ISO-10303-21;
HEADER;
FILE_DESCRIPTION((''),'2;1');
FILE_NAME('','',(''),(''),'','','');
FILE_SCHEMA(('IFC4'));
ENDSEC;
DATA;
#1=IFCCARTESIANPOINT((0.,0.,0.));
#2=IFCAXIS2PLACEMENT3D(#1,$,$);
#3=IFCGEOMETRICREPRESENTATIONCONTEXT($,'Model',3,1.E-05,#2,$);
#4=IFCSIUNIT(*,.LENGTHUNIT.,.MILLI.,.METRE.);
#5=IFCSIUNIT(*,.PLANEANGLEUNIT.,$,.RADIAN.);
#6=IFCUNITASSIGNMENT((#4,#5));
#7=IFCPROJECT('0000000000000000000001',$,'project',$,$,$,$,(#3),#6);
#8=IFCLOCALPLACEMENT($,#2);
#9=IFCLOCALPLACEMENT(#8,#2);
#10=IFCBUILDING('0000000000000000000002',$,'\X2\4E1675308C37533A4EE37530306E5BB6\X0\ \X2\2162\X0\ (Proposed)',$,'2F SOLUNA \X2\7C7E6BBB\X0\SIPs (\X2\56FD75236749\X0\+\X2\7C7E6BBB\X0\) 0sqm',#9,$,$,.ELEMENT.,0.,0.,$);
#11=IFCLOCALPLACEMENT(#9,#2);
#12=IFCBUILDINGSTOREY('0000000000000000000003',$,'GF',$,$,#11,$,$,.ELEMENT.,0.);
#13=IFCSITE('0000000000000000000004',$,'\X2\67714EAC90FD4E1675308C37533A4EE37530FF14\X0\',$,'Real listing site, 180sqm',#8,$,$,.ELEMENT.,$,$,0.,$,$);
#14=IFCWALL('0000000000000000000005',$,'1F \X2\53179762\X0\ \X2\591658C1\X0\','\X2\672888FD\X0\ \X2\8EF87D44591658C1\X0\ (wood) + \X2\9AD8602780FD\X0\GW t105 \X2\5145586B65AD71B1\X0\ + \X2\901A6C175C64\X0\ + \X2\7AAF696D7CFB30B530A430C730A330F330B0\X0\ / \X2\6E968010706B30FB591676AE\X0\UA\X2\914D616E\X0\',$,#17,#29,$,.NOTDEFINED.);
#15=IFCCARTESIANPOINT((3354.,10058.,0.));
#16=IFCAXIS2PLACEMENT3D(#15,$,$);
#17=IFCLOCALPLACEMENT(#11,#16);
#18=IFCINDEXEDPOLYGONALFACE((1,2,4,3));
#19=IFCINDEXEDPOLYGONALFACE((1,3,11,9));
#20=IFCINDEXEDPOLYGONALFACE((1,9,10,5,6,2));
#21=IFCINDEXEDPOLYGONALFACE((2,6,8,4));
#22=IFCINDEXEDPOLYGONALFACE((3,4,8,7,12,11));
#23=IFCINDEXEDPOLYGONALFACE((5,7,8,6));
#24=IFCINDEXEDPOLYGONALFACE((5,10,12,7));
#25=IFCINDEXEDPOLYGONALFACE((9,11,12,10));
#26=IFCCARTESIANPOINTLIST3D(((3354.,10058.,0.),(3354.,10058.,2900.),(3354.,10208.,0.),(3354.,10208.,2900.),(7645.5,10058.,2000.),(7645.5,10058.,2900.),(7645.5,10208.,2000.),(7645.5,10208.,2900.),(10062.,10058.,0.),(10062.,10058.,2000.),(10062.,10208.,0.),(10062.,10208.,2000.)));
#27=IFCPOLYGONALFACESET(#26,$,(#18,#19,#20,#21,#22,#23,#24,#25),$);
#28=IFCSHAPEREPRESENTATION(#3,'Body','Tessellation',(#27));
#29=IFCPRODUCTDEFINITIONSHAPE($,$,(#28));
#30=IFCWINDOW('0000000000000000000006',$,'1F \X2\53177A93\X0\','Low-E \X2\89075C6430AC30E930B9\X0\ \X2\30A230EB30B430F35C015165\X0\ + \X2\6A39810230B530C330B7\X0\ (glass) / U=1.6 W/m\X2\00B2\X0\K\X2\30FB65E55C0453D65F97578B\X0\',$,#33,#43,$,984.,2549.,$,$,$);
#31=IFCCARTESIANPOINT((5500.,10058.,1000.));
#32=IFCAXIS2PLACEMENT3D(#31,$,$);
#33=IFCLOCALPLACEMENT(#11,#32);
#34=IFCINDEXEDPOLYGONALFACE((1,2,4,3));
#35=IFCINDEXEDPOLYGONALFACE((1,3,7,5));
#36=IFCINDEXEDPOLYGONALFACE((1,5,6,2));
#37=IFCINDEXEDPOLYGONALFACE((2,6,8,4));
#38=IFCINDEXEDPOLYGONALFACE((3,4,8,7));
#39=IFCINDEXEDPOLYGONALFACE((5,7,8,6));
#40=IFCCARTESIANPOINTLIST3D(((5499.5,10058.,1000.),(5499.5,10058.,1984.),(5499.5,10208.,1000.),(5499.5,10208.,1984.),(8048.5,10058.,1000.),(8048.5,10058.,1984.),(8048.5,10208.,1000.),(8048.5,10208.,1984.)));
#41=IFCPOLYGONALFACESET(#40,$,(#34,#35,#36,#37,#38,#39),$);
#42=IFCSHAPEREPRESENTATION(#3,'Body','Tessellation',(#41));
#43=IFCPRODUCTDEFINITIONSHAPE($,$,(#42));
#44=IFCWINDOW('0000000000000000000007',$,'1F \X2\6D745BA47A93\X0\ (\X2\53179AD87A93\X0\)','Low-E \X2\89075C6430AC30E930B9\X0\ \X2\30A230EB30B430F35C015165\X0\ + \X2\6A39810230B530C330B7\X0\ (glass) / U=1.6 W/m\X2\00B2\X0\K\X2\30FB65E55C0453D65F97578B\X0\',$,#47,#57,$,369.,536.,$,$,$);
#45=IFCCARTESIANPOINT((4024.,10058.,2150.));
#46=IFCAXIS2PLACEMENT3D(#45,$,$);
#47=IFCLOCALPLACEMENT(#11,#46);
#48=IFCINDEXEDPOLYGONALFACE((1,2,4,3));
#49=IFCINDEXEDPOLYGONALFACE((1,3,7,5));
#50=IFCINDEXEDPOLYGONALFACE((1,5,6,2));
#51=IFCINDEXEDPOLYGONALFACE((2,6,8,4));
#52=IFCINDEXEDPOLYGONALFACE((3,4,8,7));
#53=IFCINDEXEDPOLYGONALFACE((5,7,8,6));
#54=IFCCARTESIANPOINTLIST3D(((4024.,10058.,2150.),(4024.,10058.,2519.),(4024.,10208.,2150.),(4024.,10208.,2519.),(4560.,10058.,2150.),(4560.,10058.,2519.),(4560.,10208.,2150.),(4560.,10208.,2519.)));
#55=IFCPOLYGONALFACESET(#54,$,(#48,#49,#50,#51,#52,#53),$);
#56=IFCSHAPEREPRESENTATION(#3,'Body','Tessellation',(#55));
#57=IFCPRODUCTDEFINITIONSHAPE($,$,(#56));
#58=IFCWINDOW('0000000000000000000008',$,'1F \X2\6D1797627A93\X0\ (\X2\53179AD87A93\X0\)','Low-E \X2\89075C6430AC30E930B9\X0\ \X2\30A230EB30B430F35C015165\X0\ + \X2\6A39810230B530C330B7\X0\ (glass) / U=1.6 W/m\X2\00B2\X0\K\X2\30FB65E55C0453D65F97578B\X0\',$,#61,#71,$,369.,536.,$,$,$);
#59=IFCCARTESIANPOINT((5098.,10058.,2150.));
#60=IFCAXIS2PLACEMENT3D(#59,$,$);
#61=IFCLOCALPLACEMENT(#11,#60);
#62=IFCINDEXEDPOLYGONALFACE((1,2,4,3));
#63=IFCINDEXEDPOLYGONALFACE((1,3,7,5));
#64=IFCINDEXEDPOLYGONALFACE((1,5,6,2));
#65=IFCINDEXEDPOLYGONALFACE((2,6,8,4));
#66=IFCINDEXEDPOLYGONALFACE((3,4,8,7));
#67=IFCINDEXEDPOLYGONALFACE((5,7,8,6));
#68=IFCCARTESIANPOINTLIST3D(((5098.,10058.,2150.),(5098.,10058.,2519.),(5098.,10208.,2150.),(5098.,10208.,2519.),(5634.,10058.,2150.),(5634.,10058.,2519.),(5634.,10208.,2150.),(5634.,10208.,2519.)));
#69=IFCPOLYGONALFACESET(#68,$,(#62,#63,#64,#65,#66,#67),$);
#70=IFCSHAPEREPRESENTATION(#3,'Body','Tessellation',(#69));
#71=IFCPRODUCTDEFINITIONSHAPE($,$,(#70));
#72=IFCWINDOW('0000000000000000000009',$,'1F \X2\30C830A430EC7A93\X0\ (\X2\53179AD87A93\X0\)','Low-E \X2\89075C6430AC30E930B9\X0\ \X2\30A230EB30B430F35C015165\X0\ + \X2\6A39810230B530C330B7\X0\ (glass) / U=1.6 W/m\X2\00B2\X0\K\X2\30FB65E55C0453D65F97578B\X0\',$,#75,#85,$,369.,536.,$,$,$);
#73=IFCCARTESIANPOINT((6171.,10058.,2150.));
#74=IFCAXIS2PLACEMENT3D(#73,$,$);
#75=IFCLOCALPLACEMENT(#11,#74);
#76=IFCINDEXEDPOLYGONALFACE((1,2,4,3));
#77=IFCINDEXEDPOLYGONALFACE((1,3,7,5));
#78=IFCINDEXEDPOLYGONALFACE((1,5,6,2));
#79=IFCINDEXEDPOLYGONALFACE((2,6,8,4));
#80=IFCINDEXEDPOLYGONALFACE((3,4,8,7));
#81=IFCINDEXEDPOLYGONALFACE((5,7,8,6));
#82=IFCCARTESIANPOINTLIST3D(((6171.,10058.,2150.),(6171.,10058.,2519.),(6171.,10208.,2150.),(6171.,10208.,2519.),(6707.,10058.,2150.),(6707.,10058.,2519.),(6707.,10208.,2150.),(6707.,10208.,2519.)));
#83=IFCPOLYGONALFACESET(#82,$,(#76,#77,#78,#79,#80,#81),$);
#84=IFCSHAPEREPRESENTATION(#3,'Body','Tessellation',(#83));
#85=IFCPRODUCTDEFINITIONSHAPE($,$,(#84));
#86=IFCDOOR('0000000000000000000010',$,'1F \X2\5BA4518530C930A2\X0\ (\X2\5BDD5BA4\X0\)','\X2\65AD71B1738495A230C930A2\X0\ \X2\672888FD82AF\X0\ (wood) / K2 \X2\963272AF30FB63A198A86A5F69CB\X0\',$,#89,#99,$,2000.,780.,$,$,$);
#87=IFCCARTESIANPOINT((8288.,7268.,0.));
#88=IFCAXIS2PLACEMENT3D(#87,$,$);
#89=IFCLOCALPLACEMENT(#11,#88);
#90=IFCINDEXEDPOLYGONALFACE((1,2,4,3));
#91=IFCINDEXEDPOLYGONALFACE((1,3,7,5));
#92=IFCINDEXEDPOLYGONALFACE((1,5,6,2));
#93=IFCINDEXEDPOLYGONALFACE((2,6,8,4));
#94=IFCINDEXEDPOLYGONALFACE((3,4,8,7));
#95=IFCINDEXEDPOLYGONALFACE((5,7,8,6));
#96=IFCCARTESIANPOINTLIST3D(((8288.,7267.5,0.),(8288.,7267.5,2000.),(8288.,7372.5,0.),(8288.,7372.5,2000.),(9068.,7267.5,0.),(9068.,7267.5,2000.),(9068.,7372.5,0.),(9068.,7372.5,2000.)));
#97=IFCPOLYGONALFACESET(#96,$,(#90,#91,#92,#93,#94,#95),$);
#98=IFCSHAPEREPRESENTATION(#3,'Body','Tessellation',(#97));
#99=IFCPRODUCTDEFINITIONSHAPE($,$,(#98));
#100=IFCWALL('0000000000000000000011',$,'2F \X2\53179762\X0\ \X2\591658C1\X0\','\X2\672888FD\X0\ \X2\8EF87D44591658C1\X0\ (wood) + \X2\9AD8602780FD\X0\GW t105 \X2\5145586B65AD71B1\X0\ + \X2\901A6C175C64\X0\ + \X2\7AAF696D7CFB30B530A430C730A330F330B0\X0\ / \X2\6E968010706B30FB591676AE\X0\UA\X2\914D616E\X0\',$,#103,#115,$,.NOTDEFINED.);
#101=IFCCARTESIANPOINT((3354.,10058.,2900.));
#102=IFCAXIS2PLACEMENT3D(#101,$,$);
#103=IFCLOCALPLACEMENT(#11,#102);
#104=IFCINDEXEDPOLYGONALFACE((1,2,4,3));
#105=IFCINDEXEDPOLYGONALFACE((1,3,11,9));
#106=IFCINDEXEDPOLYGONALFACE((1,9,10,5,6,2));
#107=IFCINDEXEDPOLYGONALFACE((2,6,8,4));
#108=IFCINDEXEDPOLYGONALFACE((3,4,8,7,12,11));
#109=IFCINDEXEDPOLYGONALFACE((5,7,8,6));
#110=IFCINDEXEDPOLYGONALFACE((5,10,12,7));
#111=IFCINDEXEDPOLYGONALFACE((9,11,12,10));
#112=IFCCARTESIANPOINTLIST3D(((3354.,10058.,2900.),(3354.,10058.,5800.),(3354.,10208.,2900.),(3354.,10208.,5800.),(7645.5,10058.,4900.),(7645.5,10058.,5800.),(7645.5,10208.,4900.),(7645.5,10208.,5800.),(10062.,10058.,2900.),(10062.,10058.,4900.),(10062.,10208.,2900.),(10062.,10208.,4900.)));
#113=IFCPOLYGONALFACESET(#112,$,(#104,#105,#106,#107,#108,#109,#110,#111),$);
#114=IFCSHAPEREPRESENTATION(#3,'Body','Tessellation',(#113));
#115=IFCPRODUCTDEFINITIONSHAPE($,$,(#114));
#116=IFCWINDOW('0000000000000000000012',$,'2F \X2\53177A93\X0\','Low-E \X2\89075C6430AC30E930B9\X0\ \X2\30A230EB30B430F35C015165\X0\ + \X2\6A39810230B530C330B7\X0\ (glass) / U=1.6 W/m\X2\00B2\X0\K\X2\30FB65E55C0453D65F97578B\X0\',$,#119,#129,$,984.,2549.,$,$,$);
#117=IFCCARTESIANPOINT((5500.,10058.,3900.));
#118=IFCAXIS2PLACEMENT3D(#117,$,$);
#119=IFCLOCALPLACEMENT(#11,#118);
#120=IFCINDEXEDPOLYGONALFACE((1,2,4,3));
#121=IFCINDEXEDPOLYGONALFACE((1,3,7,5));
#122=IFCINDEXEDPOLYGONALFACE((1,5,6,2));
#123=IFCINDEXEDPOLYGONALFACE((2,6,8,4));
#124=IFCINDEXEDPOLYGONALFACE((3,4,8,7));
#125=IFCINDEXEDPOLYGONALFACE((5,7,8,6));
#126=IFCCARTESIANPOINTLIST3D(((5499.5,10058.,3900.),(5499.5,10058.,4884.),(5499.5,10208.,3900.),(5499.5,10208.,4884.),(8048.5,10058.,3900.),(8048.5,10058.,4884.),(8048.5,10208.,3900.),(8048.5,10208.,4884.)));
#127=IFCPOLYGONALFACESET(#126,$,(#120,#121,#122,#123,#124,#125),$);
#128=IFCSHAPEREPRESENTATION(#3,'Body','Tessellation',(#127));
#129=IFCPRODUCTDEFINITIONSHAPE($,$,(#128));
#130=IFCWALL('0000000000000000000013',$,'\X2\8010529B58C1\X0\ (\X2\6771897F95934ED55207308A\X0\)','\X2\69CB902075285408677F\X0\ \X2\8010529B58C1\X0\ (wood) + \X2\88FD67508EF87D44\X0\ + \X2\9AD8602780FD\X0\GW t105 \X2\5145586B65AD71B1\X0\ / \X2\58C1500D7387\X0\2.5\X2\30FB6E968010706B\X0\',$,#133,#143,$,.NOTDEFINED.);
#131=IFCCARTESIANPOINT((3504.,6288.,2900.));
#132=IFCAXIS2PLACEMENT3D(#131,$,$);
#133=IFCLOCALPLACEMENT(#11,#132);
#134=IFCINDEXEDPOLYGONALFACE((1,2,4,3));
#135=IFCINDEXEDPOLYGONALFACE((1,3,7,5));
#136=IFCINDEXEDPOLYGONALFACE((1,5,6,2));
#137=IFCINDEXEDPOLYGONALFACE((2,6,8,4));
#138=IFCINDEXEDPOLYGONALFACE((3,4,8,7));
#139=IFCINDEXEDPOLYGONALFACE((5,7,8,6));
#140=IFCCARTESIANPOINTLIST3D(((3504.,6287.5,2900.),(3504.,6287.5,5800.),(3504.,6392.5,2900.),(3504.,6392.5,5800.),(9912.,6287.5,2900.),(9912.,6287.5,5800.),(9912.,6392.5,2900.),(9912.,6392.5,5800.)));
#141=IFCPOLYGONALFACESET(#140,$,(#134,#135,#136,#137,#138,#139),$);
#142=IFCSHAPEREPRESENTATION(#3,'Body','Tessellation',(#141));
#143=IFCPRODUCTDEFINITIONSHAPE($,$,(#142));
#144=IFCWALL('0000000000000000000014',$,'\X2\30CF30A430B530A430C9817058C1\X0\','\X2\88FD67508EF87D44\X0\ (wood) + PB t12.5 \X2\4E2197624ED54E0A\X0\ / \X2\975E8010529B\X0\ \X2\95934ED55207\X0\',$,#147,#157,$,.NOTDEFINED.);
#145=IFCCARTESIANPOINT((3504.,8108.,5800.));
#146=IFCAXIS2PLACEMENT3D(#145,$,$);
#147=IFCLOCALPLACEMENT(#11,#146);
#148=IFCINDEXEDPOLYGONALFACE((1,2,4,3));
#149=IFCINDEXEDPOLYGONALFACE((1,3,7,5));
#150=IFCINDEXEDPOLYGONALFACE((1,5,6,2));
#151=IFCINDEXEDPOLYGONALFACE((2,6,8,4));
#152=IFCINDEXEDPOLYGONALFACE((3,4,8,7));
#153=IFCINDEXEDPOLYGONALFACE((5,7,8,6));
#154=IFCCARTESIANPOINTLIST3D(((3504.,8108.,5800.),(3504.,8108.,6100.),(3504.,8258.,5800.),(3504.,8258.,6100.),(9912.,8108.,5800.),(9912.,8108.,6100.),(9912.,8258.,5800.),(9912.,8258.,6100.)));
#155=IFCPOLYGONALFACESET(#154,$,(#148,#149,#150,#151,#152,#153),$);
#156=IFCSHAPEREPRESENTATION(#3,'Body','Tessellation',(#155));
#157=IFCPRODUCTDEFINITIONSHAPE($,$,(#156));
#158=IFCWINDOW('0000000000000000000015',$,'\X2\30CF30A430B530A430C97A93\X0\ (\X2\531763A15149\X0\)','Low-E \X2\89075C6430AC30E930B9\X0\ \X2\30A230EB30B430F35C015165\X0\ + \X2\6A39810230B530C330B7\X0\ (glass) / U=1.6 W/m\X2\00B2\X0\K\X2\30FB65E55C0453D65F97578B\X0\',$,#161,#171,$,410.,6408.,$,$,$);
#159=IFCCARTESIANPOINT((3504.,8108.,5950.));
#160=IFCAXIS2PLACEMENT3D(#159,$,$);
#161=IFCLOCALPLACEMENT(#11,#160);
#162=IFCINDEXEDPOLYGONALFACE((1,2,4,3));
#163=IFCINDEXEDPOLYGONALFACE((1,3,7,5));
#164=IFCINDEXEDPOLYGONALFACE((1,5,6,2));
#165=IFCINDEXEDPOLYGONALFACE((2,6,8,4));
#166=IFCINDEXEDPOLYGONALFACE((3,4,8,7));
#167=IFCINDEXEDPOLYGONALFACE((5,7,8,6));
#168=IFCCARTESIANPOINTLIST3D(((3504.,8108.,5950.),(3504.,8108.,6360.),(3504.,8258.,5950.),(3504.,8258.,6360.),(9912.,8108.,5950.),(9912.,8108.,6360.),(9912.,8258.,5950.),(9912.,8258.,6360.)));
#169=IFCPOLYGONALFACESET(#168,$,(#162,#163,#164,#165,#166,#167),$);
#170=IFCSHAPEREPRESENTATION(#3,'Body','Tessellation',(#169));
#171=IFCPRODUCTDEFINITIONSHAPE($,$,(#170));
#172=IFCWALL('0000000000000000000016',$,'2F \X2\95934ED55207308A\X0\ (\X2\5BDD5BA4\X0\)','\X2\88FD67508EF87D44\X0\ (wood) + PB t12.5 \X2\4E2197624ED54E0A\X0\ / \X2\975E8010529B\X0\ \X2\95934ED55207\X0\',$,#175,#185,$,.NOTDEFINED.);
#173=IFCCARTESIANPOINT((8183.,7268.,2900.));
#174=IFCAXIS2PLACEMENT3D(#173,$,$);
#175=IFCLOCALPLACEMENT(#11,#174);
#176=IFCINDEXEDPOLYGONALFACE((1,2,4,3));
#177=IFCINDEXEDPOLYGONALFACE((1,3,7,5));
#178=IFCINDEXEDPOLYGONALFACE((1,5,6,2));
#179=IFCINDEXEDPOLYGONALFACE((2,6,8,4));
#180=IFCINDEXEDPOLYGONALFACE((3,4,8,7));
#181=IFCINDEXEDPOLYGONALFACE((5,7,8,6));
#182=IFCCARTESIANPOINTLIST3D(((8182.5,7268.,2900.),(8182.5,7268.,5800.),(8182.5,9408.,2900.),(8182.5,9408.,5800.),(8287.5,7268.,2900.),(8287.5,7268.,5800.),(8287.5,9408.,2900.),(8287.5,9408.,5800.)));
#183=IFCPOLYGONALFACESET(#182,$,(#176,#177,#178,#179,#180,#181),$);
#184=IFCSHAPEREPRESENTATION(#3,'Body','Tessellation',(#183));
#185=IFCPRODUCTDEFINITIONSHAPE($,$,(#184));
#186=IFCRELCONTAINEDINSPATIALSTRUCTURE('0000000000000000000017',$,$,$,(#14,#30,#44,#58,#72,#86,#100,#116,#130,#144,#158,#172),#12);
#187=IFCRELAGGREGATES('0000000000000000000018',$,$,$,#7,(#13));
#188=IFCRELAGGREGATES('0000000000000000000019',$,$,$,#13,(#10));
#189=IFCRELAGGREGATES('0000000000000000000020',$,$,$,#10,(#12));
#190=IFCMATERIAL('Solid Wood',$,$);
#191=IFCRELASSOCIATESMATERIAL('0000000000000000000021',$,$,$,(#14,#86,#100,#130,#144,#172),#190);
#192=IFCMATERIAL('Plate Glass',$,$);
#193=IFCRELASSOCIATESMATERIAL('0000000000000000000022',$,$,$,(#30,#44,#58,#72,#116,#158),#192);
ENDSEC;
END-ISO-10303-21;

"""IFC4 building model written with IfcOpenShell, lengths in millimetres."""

from ifc_helpers import new_model, si_unit, frame, frame_2d, origin, place, context, project, spatial, rectangle, extrude, material, element, fill, save


model = new_model("IFC4")

# Units and contexts
model_context = context("Model", 3, precision=1e-05, world=origin())
ifc_project = project(units=[si_unit("LENGTHUNIT", "METRE", prefix="MILLI"), si_unit("PLANEANGLEUNIT", "RADIAN")], contexts=[model_context])

# Site, building, storey
site_placement = place(None, origin())
site = spatial("IfcSite", under=ifc_project, at=site_placement, Name="東京都世田谷区代田４", ObjectType="Real listing site, 180sqm", CompositionType="ELEMENT", RefElevation=0.0)
building_placement = place(site_placement, origin())
building = spatial("IfcBuilding", under=site, at=building_placement, Name="世田谷区代田の家 Ⅲ (Proposed)", ObjectType="2F SOLUNA 籾殻SIPs (国産杉+籾殻) 0sqm", CompositionType="ELEMENT", ElevationOfRefHeight=0.0, ElevationOfTerrain=0.0)
storey_placement = place(building_placement, origin())
storey = spatial("IfcBuildingStorey", under=building, at=storey_placement, Name="GF", CompositionType="ELEMENT", Elevation=0.0)

# Wall, openings, windows
ifc_material_1 = material(Name="Solid Wood")
wall_1_placement = place(storey_placement, frame((3354.0, 10058.0, 0.0)))
wall_1 = element("IfcWall", 1, at=wall_1_placement, inside=storey, material=ifc_material_1, Name="1F 北面 外壁", Description="木製 軸組外壁 (wood) + 高性能GW t105 充填断熱 + 通気層 + 窯業系サイディング / 準耐火・外皮UA配慮", PredefinedType="NOTDEFINED", context=model_context, shape_type="SweptSolid", body=[
    extrude(rectangle(XDim=6708.0, YDim=150.0, at=frame_2d((3354.0, 75.0))), frame((3354.0, 10058.0, 0.0)), (0.0, 0.0, 1.0), 2900.0),
])
opening_1_placement = place(storey_placement, frame((5500.0, 10058.0, 1000.0)))
opening_1 = element("IfcOpeningElement", 2, at=opening_1_placement, cuts=wall_1, PredefinedType="NOTDEFINED", context=model_context, shape_type="SweptSolid", body=[
    extrude(rectangle(XDim=2549.0, YDim=150.0, at=frame_2d((1274.0, 75.0))), frame((5500.0, 10058.0, 1000.0)), (0.0, 0.0, 1.0), 984.0),
])
opening_2_placement = place(storey_placement, frame((4024.0, 10058.0, 2150.0)))
opening_2 = element("IfcOpeningElement", 3, at=opening_2_placement, cuts=wall_1, PredefinedType="NOTDEFINED", context=model_context, shape_type="SweptSolid", body=[
    extrude(rectangle(XDim=536.0, YDim=150.0, at=frame_2d((268.0, 75.0))), frame((4024.0, 10058.0, 2150.0)), (0.0, 0.0, 1.0), 369.0),
])
opening_3_placement = place(storey_placement, frame((5098.0, 10058.0, 2150.0)))
opening_3 = element("IfcOpeningElement", 4, at=opening_3_placement, cuts=wall_1, PredefinedType="NOTDEFINED", context=model_context, shape_type="SweptSolid", body=[
    extrude(rectangle(XDim=536.0, YDim=150.0, at=frame_2d((268.0, 75.0))), frame((5098.0, 10058.0, 2150.0)), (0.0, 0.0, 1.0), 369.0),
])
opening_4_placement = place(storey_placement, frame((6171.0, 10058.0, 2150.0)))
opening_4 = element("IfcOpeningElement", 5, at=opening_4_placement, cuts=wall_1, PredefinedType="NOTDEFINED", context=model_context, shape_type="SweptSolid", body=[
    extrude(rectangle(XDim=536.0, YDim=150.0, at=frame_2d((268.0, 75.0))), frame((6171.0, 10058.0, 2150.0)), (0.0, 0.0, 1.0), 369.0),
])
ifc_material_2 = material(Name="Plate Glass")
window_1_placement = place(storey_placement, frame((5500.0, 10058.0, 1000.0)))
window_1 = element("IfcWindow", 6, at=window_1_placement, inside=storey, material=ifc_material_2, Name="1F 北窓", Description="Low-E 複層ガラス アルゴン封入 + 樹脂サッシ (glass) / U=1.6 W/m²K・日射取得型", OverallHeight=984.0, OverallWidth=2549.0, context=model_context, shape_type="SweptSolid", body=[
    extrude(rectangle(XDim=2549.0, YDim=150.0, at=frame_2d((1274.0, 75.0))), frame((5500.0, 10058.0, 1000.0)), (0.0, 0.0, 1.0), 984.0),
])
fill(opening_1, window_1)
window_2_placement = place(storey_placement, frame((4024.0, 10058.0, 2150.0)))
window_2 = element("IfcWindow", 7, at=window_2_placement, inside=storey, material=ifc_material_2, Name="1F 浴室窓 (北高窓)", Description="Low-E 複層ガラス アルゴン封入 + 樹脂サッシ (glass) / U=1.6 W/m²K・日射取得型", OverallHeight=369.0, OverallWidth=536.0, context=model_context, shape_type="SweptSolid", body=[
    extrude(rectangle(XDim=536.0, YDim=150.0, at=frame_2d((268.0, 75.0))), frame((4024.0, 10058.0, 2150.0)), (0.0, 0.0, 1.0), 369.0),
])
fill(opening_2, window_2)
window_3_placement = place(storey_placement, frame((5098.0, 10058.0, 2150.0)))
window_3 = element("IfcWindow", 8, at=window_3_placement, inside=storey, material=ifc_material_2, Name="1F 洗面窓 (北高窓)", Description="Low-E 複層ガラス アルゴン封入 + 樹脂サッシ (glass) / U=1.6 W/m²K・日射取得型", OverallHeight=369.0, OverallWidth=536.0, context=model_context, shape_type="SweptSolid", body=[
    extrude(rectangle(XDim=536.0, YDim=150.0, at=frame_2d((268.0, 75.0))), frame((5098.0, 10058.0, 2150.0)), (0.0, 0.0, 1.0), 369.0),
])
fill(opening_3, window_3)
window_4_placement = place(storey_placement, frame((6171.0, 10058.0, 2150.0)))
window_4 = element("IfcWindow", 9, at=window_4_placement, inside=storey, material=ifc_material_2, Name="1F トイレ窓 (北高窓)", Description="Low-E 複層ガラス アルゴン封入 + 樹脂サッシ (glass) / U=1.6 W/m²K・日射取得型", OverallHeight=369.0, OverallWidth=536.0, context=model_context, shape_type="SweptSolid", body=[
    extrude(rectangle(XDim=536.0, YDim=150.0, at=frame_2d((268.0, 75.0))), frame((6171.0, 10058.0, 2150.0)), (0.0, 0.0, 1.0), 369.0),
])
fill(opening_4, window_4)

# Door
door_1_placement = place(storey_placement, frame((8288.0, 7268.0, 0.0)))
element("IfcDoor", 10, at=door_1_placement, inside=storey, material=ifc_material_1, Name="1F 室内ドア (寝室)", Description="断熱玄関ドア 木製芯 (wood) / K2 防犯・採風機構", OverallHeight=2000.0, OverallWidth=780.0, context=model_context, shape_type="SweptSolid", body=[
    extrude(rectangle(XDim=780.0, YDim=105.0, at=frame_2d((390.0, 52.0))), frame((8288.0, 7268.0, 0.0)), (0.0, 0.0, 1.0), 2000.0),
])

# Wall, opening, window
wall_2_placement = place(storey_placement, frame((3354.0, 10058.0, 2900.0)))
wall_2 = element("IfcWall", 11, at=wall_2_placement, inside=storey, material=ifc_material_1, Name="2F 北面 外壁", Description="木製 軸組外壁 (wood) + 高性能GW t105 充填断熱 + 通気層 + 窯業系サイディング / 準耐火・外皮UA配慮", PredefinedType="NOTDEFINED", context=model_context, shape_type="SweptSolid", body=[
    extrude(rectangle(XDim=6708.0, YDim=150.0, at=frame_2d((3354.0, 75.0))), frame((3354.0, 10058.0, 2900.0)), (0.0, 0.0, 1.0), 2900.0),
])
opening_5_placement = place(storey_placement, frame((5500.0, 10058.0, 3900.0)))
opening_5 = element("IfcOpeningElement", 12, at=opening_5_placement, cuts=wall_2, PredefinedType="NOTDEFINED", context=model_context, shape_type="SweptSolid", body=[
    extrude(rectangle(XDim=2549.0, YDim=150.0, at=frame_2d((1274.0, 75.0))), frame((5500.0, 10058.0, 3900.0)), (0.0, 0.0, 1.0), 984.0),
])
window_5_placement = place(storey_placement, frame((5500.0, 10058.0, 3900.0)))
window_5 = element("IfcWindow", 13, at=window_5_placement, inside=storey, material=ifc_material_2, Name="2F 北窓", Description="Low-E 複層ガラス アルゴン封入 + 樹脂サッシ (glass) / U=1.6 W/m²K・日射取得型", OverallHeight=984.0, OverallWidth=2549.0, context=model_context, shape_type="SweptSolid", body=[
    extrude(rectangle(XDim=2549.0, YDim=150.0, at=frame_2d((1274.0, 75.0))), frame((5500.0, 10058.0, 3900.0)), (0.0, 0.0, 1.0), 984.0),
])
fill(opening_5, window_5)

# Wall
wall_3_placement = place(storey_placement, frame((3504.0, 6288.0, 2900.0)))
element("IfcWall", 14, at=wall_3_placement, inside=storey, material=ifc_material_1, Name="耐力壁 (東西間仕切り)", Description="構造用合板 耐力壁 (wood) + 製材軸組 + 高性能GW t105 充填断熱 / 壁倍率2.5・準耐火", PredefinedType="NOTDEFINED", context=model_context, shape_type="SweptSolid", body=[
    extrude(rectangle(XDim=6408.0, YDim=105.0, at=frame_2d((3204.0, 52.0))), frame((3504.0, 6288.0, 2900.0)), (0.0, 0.0, 1.0), 2900.0),
])

# Wall, opening, window
wall_4_placement = place(storey_placement, frame((3504.0, 8108.0, 5800.0)))
wall_4 = element("IfcWall", 15, at=wall_4_placement, inside=storey, material=ifc_material_1, Name="ハイサイド腰壁", Description="製材軸組 (wood) + PB t12.5 両面仕上 / 非耐力 間仕切", PredefinedType="NOTDEFINED", context=model_context, shape_type="SweptSolid", body=[
    extrude(rectangle(XDim=6408.0, YDim=150.0, at=frame_2d((3204.0, 75.0))), frame((3504.0, 8108.0, 5800.0)), (0.0, 0.0, 1.0), 700.0),
])
opening_6_placement = place(storey_placement, frame((3504.0, 8108.0, 5950.0)))
opening_6 = element("IfcOpeningElement", 16, at=opening_6_placement, cuts=wall_4, PredefinedType="NOTDEFINED", context=model_context, shape_type="SweptSolid", body=[
    extrude(rectangle(XDim=6408.0, YDim=150.0, at=frame_2d((3204.0, 75.0))), frame((3504.0, 8108.0, 5950.0)), (0.0, 0.0, 1.0), 410.0),
])
window_6_placement = place(storey_placement, frame((3504.0, 8108.0, 5950.0)))
window_6 = element("IfcWindow", 17, at=window_6_placement, inside=storey, material=ifc_material_2, Name="ハイサイド窓 (北採光)", Description="Low-E 複層ガラス アルゴン封入 + 樹脂サッシ (glass) / U=1.6 W/m²K・日射取得型", OverallHeight=410.0, OverallWidth=6408.0, context=model_context, shape_type="SweptSolid", body=[
    extrude(rectangle(XDim=6408.0, YDim=150.0, at=frame_2d((3204.0, 75.0))), frame((3504.0, 8108.0, 5950.0)), (0.0, 0.0, 1.0), 410.0),
])
fill(opening_6, window_6)

# Wall
wall_5_placement = place(storey_placement, frame((8183.0, 7268.0, 2900.0)))
element("IfcWall", 18, at=wall_5_placement, inside=storey, material=ifc_material_1, Name="2F 間仕切り (寝室)", Description="製材軸組 (wood) + PB t12.5 両面仕上 / 非耐力 間仕切", PredefinedType="NOTDEFINED", context=model_context, shape_type="SweptSolid", body=[
    extrude(rectangle(XDim=105.0, YDim=2140.0, at=frame_2d((52.0, 1070.0))), frame((8183.0, 7268.0, 2900.0)), (0.0, 0.0, 1.0), 2900.0),
])

save(model, "model.ifc")
